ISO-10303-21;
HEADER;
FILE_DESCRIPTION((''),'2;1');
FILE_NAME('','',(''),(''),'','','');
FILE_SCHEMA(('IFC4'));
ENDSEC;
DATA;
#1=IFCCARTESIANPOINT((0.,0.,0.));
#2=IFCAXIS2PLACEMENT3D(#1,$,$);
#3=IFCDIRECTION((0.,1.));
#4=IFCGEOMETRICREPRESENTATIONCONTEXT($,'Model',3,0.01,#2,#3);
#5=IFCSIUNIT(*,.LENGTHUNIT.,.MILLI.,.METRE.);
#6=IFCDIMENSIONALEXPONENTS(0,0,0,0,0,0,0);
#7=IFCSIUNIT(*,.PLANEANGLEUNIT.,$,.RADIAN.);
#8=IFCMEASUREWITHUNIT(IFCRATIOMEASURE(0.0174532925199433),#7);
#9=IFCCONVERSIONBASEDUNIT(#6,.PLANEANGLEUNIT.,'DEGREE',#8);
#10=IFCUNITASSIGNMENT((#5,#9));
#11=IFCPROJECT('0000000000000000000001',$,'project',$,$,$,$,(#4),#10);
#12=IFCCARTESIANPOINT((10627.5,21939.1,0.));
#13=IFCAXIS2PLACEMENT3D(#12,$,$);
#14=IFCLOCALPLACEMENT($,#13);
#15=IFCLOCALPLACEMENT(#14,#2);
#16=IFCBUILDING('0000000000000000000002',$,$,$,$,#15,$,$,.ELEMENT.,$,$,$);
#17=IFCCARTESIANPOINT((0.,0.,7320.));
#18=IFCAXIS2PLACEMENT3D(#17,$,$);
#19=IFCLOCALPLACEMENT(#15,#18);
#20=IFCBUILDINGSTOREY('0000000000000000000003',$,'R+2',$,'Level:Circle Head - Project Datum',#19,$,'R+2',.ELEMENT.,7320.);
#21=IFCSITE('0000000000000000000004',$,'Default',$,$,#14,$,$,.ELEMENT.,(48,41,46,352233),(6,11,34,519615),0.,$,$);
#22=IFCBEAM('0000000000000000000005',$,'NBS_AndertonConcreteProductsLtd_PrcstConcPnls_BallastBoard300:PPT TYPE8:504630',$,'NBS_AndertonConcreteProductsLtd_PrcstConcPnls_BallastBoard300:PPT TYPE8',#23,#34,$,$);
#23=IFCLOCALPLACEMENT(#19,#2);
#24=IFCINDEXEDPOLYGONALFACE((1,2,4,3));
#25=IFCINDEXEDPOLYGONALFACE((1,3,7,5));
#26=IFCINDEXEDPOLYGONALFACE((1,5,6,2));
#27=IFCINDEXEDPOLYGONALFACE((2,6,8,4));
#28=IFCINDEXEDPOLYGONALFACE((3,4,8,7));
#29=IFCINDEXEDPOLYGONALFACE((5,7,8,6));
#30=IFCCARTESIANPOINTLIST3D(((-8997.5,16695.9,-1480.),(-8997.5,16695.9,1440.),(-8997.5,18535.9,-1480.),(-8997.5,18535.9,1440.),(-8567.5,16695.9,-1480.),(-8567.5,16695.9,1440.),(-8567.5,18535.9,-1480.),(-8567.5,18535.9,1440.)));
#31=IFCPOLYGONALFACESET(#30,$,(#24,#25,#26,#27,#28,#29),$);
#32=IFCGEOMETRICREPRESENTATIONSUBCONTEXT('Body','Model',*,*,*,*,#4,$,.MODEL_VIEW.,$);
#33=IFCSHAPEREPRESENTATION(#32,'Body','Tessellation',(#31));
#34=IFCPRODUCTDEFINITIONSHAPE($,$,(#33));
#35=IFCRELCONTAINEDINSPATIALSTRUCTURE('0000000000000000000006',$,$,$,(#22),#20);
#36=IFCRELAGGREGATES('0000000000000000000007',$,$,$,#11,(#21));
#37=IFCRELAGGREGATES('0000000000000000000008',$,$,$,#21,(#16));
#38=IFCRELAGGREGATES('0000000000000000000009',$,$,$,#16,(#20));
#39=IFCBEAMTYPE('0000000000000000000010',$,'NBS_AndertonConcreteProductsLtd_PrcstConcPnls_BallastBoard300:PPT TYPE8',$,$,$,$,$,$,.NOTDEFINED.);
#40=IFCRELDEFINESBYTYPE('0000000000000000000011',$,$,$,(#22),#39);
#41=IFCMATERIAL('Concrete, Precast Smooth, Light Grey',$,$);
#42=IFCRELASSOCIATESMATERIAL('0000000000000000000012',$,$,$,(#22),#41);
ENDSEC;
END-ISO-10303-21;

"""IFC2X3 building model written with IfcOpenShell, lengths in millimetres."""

from ifc_helpers import new_model, entity, si_unit, converted_unit, direction, frame, frame_2d, origin, place, context, subcontext, project, spatial, rectangle, extrude, material, type_object, element, save


model = new_model("IFC2X3")

# Units and contexts
model_context = context("Model", 3, precision=0.01, world=origin(), true_north=direction((0.0, 1.0)))
body_context = subcontext(model_context, "Body", "Model", "MODEL_VIEW")
ifc_project = project(units=[si_unit("LENGTHUNIT", "METRE", prefix="MILLI"), converted_unit("PLANEANGLEUNIT", "DEGREE", entity("IfcRatioMeasure", 0.0174532925199433), si_unit("PLANEANGLEUNIT", "RADIAN"), dimensions=[0, 0, 0, 0, 0, 0, 0])], contexts=[model_context])

# Site, building, storey
site_placement = place(None, frame((10627.5, 21939.1, 0.0)))
site = spatial("IfcSite", under=ifc_project, at=site_placement, Name="Default", CompositionType="ELEMENT", RefLatitude=(48, 41, 46, 352233), RefLongitude=(6, 11, 34, 519615), RefElevation=0.0)
building_placement = place(site_placement, origin())
building = spatial("IfcBuilding", under=site, at=building_placement, CompositionType="ELEMENT")
storey_placement = place(building_placement, frame((0.0, 0.0, 7320.0)))
storey = spatial("IfcBuildingStorey", under=building, at=storey_placement, Name="R+2", ObjectType="Level:Circle Head - Project Datum", LongName="R+2", CompositionType="ELEMENT", Elevation=7320.0)

# Shared definitions
ifc_material = material(Name="Concrete, Precast Smooth, Light Grey")

# Beam
beam_type_1 = type_object("IfcBeamType", Name="NBS_AndertonConcreteProductsLtd_PrcstConcPnls_BallastBoard300:PPT TYPE8", PredefinedType="NOTDEFINED")
beam_1_placement = place(storey_placement, origin())
element("IfcBeam", 1, at=beam_1_placement, inside=storey, type_object=beam_type_1, material=ifc_material, Name="NBS_AndertonConcreteProductsLtd_PrcstConcPnls_BallastBoard300:PPT TYPE8:504630", ObjectType="NBS_AndertonConcreteProductsLtd_PrcstConcPnls_BallastBoard300:PPT TYPE8", context=body_context, shape_type="SweptSolid", body=[
    extrude(rectangle(XDim=2920.0, YDim=1840.0, at=frame_2d((0.0, 0.0), x_axis=(0.0, 1.0))), frame((-8997.5, 17615.9, -20.0), z_axis=(1.0, 0.0, 0.0), x_axis=(0.0, -1.0, 0.0)), (0.0, 0.0, 1.0), 430.0),
])

save(model, "model.ifc")
